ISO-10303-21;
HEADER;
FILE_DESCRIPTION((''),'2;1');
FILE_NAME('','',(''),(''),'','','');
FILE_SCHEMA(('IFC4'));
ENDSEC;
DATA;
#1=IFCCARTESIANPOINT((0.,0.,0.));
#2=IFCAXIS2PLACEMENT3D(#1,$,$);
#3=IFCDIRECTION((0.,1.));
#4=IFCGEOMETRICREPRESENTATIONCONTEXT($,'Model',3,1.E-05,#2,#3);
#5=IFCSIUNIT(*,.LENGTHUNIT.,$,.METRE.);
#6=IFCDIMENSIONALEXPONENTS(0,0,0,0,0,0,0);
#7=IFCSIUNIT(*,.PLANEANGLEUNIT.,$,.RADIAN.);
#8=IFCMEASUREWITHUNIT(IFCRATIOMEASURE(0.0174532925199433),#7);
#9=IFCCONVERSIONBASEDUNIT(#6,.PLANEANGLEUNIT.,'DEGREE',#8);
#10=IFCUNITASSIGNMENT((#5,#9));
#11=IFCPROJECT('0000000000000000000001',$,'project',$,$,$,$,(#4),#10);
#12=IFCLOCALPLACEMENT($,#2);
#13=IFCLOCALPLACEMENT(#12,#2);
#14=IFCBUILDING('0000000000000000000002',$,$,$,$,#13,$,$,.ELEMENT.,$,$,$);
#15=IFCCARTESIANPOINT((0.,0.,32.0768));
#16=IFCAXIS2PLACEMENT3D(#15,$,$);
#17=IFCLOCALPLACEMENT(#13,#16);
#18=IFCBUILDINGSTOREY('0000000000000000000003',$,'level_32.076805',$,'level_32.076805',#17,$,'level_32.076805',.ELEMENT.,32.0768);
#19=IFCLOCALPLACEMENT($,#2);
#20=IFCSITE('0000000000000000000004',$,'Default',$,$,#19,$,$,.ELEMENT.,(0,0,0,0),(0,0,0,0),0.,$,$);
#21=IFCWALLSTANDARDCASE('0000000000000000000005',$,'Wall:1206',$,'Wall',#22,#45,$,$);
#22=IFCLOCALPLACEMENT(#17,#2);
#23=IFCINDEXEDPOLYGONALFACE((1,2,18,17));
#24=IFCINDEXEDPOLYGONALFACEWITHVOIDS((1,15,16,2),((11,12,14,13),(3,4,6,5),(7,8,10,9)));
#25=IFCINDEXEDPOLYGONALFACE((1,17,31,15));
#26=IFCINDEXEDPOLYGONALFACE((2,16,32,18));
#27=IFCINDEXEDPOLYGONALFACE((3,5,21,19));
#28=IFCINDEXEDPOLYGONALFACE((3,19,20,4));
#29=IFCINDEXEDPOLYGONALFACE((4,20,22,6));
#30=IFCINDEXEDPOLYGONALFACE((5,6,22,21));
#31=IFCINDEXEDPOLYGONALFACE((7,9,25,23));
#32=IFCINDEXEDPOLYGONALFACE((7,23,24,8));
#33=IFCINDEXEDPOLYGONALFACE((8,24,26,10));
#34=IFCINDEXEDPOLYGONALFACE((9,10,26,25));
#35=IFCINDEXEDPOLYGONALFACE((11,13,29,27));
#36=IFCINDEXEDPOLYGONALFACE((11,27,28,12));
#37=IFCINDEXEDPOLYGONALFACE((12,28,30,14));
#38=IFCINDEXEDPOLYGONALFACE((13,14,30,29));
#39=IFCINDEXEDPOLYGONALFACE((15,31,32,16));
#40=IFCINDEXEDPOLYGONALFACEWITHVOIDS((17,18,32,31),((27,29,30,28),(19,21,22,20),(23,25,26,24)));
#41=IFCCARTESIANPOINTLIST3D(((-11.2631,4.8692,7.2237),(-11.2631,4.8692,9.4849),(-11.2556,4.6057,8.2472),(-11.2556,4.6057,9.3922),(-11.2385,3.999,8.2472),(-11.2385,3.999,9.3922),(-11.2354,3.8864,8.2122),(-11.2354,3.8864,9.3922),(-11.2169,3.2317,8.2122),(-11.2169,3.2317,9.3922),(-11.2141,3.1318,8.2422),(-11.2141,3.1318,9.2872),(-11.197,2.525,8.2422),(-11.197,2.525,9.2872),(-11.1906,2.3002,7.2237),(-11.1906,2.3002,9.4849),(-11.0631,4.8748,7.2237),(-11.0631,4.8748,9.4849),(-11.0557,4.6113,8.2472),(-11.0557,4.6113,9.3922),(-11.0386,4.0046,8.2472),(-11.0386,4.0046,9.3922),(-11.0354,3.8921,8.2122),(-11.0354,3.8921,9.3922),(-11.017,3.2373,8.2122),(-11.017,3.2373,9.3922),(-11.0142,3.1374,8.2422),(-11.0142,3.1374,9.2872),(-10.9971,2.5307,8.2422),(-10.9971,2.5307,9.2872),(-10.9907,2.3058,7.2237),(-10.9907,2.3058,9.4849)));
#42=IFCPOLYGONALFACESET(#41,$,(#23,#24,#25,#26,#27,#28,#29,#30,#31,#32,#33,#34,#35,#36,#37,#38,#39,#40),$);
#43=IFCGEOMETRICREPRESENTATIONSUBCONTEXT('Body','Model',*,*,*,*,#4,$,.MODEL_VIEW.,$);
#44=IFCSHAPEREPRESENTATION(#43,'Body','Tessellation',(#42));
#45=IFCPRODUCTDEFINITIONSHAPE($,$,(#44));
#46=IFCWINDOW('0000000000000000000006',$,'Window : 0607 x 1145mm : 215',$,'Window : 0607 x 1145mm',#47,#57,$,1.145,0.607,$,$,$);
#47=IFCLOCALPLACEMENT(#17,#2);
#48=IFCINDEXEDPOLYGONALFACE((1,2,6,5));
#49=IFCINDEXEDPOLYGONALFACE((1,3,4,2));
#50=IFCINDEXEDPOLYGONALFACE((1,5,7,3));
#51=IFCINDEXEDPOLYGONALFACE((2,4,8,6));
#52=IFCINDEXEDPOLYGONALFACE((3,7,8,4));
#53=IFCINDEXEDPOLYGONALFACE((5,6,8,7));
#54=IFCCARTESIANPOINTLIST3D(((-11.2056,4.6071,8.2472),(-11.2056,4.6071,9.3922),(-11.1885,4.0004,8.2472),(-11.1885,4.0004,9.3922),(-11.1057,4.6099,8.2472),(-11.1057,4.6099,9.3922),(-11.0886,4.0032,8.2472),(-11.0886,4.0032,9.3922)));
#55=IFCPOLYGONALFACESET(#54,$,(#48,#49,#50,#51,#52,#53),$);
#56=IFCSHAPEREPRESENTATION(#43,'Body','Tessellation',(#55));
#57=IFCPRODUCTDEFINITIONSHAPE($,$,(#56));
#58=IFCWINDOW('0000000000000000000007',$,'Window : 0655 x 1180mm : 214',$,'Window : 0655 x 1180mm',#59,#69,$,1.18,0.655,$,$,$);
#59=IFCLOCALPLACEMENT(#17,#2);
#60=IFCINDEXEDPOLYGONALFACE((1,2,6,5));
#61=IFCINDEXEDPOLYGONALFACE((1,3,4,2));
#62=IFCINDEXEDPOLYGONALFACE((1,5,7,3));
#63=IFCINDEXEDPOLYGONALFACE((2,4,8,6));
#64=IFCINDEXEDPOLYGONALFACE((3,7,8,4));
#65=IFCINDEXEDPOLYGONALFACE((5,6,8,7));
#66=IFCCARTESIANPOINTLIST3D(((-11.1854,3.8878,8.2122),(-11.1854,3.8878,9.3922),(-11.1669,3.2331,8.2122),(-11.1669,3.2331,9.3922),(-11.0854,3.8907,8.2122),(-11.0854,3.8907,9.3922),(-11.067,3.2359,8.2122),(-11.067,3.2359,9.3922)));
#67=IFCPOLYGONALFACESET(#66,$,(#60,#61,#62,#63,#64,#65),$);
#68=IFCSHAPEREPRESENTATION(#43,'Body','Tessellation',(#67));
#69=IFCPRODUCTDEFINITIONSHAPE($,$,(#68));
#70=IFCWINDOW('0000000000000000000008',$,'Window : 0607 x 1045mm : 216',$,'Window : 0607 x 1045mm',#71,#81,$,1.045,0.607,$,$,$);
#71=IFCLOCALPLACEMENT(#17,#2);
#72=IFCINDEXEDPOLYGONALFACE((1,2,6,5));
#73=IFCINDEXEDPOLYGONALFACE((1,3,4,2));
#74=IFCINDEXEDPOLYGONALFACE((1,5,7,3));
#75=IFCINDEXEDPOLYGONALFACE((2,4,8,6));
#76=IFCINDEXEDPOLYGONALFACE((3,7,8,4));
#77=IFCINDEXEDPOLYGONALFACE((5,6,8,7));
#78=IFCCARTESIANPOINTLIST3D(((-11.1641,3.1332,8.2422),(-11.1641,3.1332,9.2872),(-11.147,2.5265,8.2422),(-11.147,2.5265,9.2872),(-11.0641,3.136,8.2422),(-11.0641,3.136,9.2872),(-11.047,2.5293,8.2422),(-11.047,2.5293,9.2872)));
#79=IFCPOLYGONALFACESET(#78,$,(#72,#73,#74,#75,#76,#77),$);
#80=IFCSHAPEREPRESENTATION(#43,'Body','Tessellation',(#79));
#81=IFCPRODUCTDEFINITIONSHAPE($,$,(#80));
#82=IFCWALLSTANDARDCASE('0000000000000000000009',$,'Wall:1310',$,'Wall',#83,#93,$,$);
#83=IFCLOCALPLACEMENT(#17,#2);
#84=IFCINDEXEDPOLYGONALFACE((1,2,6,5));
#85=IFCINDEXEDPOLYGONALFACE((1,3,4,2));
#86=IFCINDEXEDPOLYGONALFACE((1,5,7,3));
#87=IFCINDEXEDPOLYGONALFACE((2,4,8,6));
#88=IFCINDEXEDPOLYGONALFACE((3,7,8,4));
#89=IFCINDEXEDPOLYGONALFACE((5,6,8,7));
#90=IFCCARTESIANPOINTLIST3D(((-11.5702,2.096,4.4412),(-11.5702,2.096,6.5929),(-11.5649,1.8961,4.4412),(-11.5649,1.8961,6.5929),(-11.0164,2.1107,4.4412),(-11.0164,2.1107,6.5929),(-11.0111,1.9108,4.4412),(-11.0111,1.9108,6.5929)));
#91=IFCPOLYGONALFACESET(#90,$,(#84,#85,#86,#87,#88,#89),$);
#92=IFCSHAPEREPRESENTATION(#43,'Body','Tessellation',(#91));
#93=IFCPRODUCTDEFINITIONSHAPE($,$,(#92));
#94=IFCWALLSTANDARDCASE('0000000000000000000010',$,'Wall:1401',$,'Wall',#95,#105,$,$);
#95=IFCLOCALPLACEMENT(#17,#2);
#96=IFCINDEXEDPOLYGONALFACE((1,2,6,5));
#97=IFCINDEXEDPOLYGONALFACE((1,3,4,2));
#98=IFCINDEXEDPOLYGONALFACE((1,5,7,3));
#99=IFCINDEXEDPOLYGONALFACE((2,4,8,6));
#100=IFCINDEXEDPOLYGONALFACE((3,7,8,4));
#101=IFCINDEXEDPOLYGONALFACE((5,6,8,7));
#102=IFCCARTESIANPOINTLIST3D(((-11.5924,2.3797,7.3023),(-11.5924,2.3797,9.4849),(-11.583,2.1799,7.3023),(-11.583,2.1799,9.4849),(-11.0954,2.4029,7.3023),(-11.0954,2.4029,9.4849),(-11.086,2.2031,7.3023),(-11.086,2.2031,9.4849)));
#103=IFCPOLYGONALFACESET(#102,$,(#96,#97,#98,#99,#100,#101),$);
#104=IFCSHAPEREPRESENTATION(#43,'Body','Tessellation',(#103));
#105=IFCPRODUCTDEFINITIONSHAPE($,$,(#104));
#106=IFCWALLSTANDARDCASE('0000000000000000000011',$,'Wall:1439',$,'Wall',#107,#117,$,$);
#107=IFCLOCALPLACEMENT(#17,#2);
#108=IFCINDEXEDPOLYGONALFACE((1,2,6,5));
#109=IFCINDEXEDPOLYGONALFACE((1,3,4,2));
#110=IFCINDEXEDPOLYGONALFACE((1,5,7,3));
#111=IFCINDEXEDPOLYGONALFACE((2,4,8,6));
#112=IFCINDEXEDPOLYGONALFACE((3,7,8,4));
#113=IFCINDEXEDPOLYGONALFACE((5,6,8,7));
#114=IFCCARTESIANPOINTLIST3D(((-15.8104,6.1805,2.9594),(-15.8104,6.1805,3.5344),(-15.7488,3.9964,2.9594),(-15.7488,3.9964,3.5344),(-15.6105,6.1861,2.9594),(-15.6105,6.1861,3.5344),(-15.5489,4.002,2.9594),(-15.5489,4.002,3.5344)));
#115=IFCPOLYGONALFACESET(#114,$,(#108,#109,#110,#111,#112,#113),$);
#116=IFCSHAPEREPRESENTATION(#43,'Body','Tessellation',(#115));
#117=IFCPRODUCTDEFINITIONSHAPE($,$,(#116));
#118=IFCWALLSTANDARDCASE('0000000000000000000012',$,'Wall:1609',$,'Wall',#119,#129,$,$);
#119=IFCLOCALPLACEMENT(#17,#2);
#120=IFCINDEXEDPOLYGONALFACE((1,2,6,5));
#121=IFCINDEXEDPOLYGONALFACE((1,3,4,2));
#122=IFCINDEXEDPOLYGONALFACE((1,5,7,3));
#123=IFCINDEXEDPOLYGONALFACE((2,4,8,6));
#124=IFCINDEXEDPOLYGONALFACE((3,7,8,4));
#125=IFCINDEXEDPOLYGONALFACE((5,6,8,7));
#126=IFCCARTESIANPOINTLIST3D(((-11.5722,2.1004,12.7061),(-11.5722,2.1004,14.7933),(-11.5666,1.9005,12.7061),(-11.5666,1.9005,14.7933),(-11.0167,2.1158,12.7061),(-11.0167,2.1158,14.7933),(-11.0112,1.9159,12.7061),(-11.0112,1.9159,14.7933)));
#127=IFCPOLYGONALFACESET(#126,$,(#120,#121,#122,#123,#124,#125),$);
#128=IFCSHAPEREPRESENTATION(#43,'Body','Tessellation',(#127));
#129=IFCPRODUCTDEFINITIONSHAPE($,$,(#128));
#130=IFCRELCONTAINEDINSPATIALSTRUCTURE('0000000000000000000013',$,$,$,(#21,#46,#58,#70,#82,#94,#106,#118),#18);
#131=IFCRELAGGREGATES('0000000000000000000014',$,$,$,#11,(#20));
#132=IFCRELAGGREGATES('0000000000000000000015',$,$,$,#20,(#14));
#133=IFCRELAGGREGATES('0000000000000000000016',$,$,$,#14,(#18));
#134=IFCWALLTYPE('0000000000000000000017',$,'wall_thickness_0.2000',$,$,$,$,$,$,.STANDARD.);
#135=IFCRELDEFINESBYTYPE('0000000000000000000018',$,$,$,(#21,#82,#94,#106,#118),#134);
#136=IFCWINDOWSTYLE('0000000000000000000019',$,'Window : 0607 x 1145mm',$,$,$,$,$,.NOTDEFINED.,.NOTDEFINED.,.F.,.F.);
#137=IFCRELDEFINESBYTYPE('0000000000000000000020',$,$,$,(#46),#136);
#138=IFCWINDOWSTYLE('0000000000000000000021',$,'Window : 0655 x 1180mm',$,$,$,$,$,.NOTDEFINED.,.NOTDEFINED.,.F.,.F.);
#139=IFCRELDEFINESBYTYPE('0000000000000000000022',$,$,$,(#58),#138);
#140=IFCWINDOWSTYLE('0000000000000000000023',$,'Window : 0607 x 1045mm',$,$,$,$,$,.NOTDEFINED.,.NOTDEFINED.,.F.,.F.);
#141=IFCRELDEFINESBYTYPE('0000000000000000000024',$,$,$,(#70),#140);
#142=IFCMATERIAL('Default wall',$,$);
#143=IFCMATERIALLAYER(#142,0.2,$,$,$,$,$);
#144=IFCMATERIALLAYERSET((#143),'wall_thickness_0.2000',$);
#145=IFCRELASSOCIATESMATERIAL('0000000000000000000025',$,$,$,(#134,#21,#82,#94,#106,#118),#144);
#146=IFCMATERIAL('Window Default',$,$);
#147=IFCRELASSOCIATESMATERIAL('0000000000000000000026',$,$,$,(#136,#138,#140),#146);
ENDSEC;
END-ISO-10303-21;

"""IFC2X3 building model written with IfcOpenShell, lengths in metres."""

from ifc_helpers import new_model, entity, si_unit, converted_unit, direction, frame, frame_2d, origin, origin_2d_with_axis, place, context, subcontext, project, spatial, polyline, rectangle, outline, extrude, source, transform, mapped, material, layer, layer_set, layer_usage, type_object, type_shapes, element, fill, save


model = new_model("IFC2X3")

# Units and contexts
model_context = context("Model", 3, precision=1e-05, world=origin(), true_north=direction((0.0, 1.0)))
body_context = subcontext(model_context, "Body", "Model", "MODEL_VIEW")
ifc_project = project(units=[si_unit("LENGTHUNIT", "METRE"), converted_unit("PLANEANGLEUNIT", "DEGREE", entity("IfcRatioMeasure", 0.0174532925199433), si_unit("PLANEANGLEUNIT", "RADIAN"), dimensions=[0, 0, 0, 0, 0, 0, 0])], contexts=[model_context])

# Site, building, storey
site_placement = place(None, origin())
site = spatial("IfcSite", under=ifc_project, at=site_placement, Name="Default", CompositionType="ELEMENT", RefLatitude=(0, 0, 0, 0), RefLongitude=(0, 0, 0, 0), RefElevation=0.0)
placement_1 = place(None, origin())
building_placement = place(placement_1, origin())
building = spatial("IfcBuilding", under=site, at=building_placement, CompositionType="ELEMENT")
storey_placement = place(building_placement, frame((0.0, 0.0, 32.0768)))
storey = spatial("IfcBuildingStorey", under=building, at=storey_placement, Name="level_32.076805", ObjectType="level_32.076805", LongName="level_32.076805", CompositionType="ELEMENT", Elevation=32.0768)

# Shared definitions
ifc_material_1 = material(Name="Default wall")
ifc_layer = layer(ifc_material_1, 0.2)
ifc_layer_set = layer_set([ifc_layer], Name="wall_thickness_0.2000")
ifc_layer_usage = layer_usage(ifc_layer_set, "AXIS2", "POSITIVE", -0.1)
wall_type = type_object("IfcWallType", Name="wall_thickness_0.2000", PredefinedType="STANDARD", material=ifc_layer_set)
ifc_material_2 = material(Name="Window Default")
window_style_1 = type_object("IfcWindowStyle", Name="Window : 0607 x 1145mm", ConstructionType="NOTDEFINED", OperationType="NOTDEFINED", ParameterTakesPrecedence=False, Sizeable=False, material=ifc_material_2)
shared_shape_1 = source(origin(), body_context, "Body", "SweptSolid", [
    extrude(rectangle(XDim=0.1, YDim=0.607, at=origin_2d_with_axis()), frame((0.3035, 0.1, 0.0), z_axis=(0.0, 0.0, 1.0), x_axis=(0.0, 1.0, 0.0)), (0.0, 0.0, 1.0), 1.145),
])
type_shapes(window_style_1, [shared_shape_1])

# Shared definitions
window_style_2 = type_object("IfcWindowStyle", Name="Window : 0655 x 1180mm", ConstructionType="NOTDEFINED", OperationType="NOTDEFINED", ParameterTakesPrecedence=False, Sizeable=False, material=ifc_material_2)
shared_shape_2 = source(origin(), body_context, "Body", "SweptSolid", [
    extrude(rectangle(XDim=0.1, YDim=0.655, at=origin_2d_with_axis()), frame((0.3275, 0.1, 0.0), z_axis=(0.0, 0.0, 1.0), x_axis=(0.0, 1.0, 0.0)), (0.0, 0.0, 1.0), 1.18),
])
type_shapes(window_style_2, [shared_shape_2])
window_style_3 = type_object("IfcWindowStyle", Name="Window : 0607 x 1045mm", ConstructionType="NOTDEFINED", OperationType="NOTDEFINED", ParameterTakesPrecedence=False, Sizeable=False, material=ifc_material_2)
shared_shape_3 = source(origin(), body_context, "Body", "SweptSolid", [
    extrude(rectangle(XDim=0.1, YDim=0.607, at=origin_2d_with_axis()), frame((0.3035, 0.1, 0.0), z_axis=(0.0, 0.0, 1.0), x_axis=(0.0, 1.0, 0.0)), (0.0, 0.0, 1.0), 1.045),
])
type_shapes(window_style_3, [shared_shape_3])

# Wall, openings, windows
placement_2 = place(building_placement, frame((0.0, 0.0, 39.3005)))
wall_1_placement = place(placement_2, frame((-11.0907, 2.303, 0.0), z_axis=(0.0, 0.0, 1.0), x_axis=(-0.028173, 0.999603, 0.0)))
wall_1 = element("IfcWallStandardCase", 1, at=wall_1_placement, inside=storey, type_object=wall_type, material=ifc_layer_usage, Name="Wall:1206", ObjectType="Wall", context=body_context, shape_type="SweptSolid", body=[
    extrude(outline(polyline([(2.57, -0.1), (2.57, 0.1), (0.0, 0.1), (0.0, -0.1), (2.57, -0.1)])), origin(), (0.0, 0.0, 1.0), 2.2612),
])
opening_1_placement = place(wall_1_placement, frame((0.9319, -0.1, 0.9885)))
opening_1 = element("IfcOpeningElement", 2, at=opening_1_placement, cuts=wall_1, ObjectType="Opening", context=body_context, shape_type="SweptSolid", body=[
    extrude(rectangle(XDim=0.655, YDim=1.18, at=frame_2d((0.59, 0.3275), x_axis=(0.0, 1.0))), frame((0.0, 0.0, 0.0), z_axis=(0.0, 1.0, 0.0), x_axis=(0.0, 0.0, 1.0)), (0.0, 0.0, 1.0), 0.2),
])
opening_2_placement = place(wall_1_placement, frame((1.6994, -0.1, 1.0235)))
opening_2 = element("IfcOpeningElement", 3, at=opening_2_placement, cuts=wall_1, ObjectType="Opening", context=body_context, shape_type="SweptSolid", body=[
    extrude(rectangle(XDim=0.607, YDim=1.145, at=frame_2d((0.5725, 0.3035), x_axis=(0.0, 1.0))), frame((0.0, 0.0, 0.0), z_axis=(0.0, 1.0, 0.0), x_axis=(0.0, 0.0, 1.0)), (0.0, 0.0, 1.0), 0.2),
])
opening_3_placement = place(wall_1_placement, frame((0.2249, -0.1, 1.0185)))
opening_3 = element("IfcOpeningElement", 4, at=opening_3_placement, cuts=wall_1, ObjectType="Opening", context=body_context, shape_type="SweptSolid", body=[
    extrude(rectangle(XDim=0.607, YDim=1.045, at=frame_2d((0.5225, 0.3035), x_axis=(0.0, 1.0))), frame((0.0, 0.0, 0.0), z_axis=(0.0, 1.0, 0.0), x_axis=(0.0, 0.0, 1.0)), (0.0, 0.0, 1.0), 0.2),
])
window_1_placement = place(opening_2_placement, origin())
window_1 = element("IfcWindow", 5, at=window_1_placement, inside=storey, type_object=window_style_1, Name="Window : 0607 x 1145mm : 215", ObjectType="Window : 0607 x 1145mm", OverallHeight=1.145, OverallWidth=0.607, context=body_context, shape_type="MappedRepresentation", body=[
    mapped(shared_shape_1, transform((0.0, 0.0, 0.0), scale=1.0)),
])
fill(opening_2, window_1)
window_2_placement = place(opening_1_placement, origin())
window_2 = element("IfcWindow", 6, at=window_2_placement, inside=storey, type_object=window_style_2, Name="Window : 0655 x 1180mm : 214", ObjectType="Window : 0655 x 1180mm", OverallHeight=1.18, OverallWidth=0.655, context=body_context, shape_type="MappedRepresentation", body=[
    mapped(shared_shape_2, transform((0.0, 0.0, 0.0), scale=1.0)),
])
fill(opening_1, window_2)
window_3_placement = place(opening_3_placement, origin())
window_3 = element("IfcWindow", 7, at=window_3_placement, inside=storey, type_object=window_style_3, Name="Window : 0607 x 1045mm : 216", ObjectType="Window : 0607 x 1045mm", OverallHeight=1.045, OverallWidth=0.607, context=body_context, shape_type="MappedRepresentation", body=[
    mapped(shared_shape_3, transform((0.0, 0.0, 0.0), scale=1.0)),
])
fill(opening_3, window_3)

# Walls
placement_3 = place(building_placement, frame((0.0, 0.0, 36.518)))
wall_2_placement = place(placement_3, frame((-11.0138, 2.0107, 0.0), z_axis=(0.0, 0.0, 1.0), x_axis=(-0.999648, -0.026532, 0.0)))
element("IfcWallStandardCase", 8, at=wall_2_placement, inside=storey, type_object=wall_type, material=ifc_layer_usage, Name="Wall:1310", ObjectType="Wall", context=body_context, shape_type="SweptSolid", body=[
    extrude(outline(polyline([(0.5539, -0.1), (0.5539, 0.1), (0.0, 0.1), (0.0, -0.1), (0.5539, -0.1)])), origin(), (0.0, 0.0, 1.0), 2.1518),
])
placement_4 = place(building_placement, frame((0.0, 0.0, 39.3791)))
wall_3_placement = place(placement_4, frame((-11.0907, 2.303, 0.0), z_axis=(0.0, 0.0, 1.0), x_axis=(-0.998906, -0.046757, 0.0)))
element("IfcWallStandardCase", 9, at=wall_3_placement, inside=storey, type_object=wall_type, material=ifc_layer_usage, Name="Wall:1401", ObjectType="Wall", context=body_context, shape_type="SweptSolid", body=[
    extrude(outline(polyline([(0.4975, -0.1), (0.4975, 0.1), (0.0, 0.1), (0.0, -0.1), (0.4975, -0.1)])), origin(), (0.0, 0.0, 1.0), 2.1825),
])
placement_5 = place(building_placement, frame((0.0, 0.0, 35.0362)))
wall_4_placement = place(placement_5, frame((-15.7104, 6.1833, 0.0), z_axis=(0.0, 0.0, 1.0), x_axis=(0.028193, -0.999602, 0.0)))
element("IfcWallStandardCase", 10, at=wall_4_placement, inside=storey, type_object=wall_type, material=ifc_layer_usage, Name="Wall:1439", ObjectType="Wall", context=body_context, shape_type="SweptSolid", body=[
    extrude(outline(polyline([(2.185, -0.1), (2.185, 0.1), (0.0, 0.1), (0.0, -0.1), (2.185, -0.1)])), origin(), (0.0, 0.0, 1.0), 0.575),
])
placement_6 = place(building_placement, frame((0.0, 0.0, 44.7829)))
wall_5_placement = place(placement_6, frame((-11.0139, 2.0159, 0.0), z_axis=(0.0, 0.0, 1.0), x_axis=(-0.999614, -0.027775, 0.0)))
element("IfcWallStandardCase", 11, at=wall_5_placement, inside=storey, type_object=wall_type, material=ifc_layer_usage, Name="Wall:1609", ObjectType="Wall", context=body_context, shape_type="SweptSolid", body=[
    extrude(outline(polyline([(0.5557, -0.1), (0.5557, 0.1), (0.0, 0.1), (0.0, -0.1), (0.5557, -0.1)])), origin(), (0.0, 0.0, 1.0), 2.0872),
])

save(model, "model.ifc")
